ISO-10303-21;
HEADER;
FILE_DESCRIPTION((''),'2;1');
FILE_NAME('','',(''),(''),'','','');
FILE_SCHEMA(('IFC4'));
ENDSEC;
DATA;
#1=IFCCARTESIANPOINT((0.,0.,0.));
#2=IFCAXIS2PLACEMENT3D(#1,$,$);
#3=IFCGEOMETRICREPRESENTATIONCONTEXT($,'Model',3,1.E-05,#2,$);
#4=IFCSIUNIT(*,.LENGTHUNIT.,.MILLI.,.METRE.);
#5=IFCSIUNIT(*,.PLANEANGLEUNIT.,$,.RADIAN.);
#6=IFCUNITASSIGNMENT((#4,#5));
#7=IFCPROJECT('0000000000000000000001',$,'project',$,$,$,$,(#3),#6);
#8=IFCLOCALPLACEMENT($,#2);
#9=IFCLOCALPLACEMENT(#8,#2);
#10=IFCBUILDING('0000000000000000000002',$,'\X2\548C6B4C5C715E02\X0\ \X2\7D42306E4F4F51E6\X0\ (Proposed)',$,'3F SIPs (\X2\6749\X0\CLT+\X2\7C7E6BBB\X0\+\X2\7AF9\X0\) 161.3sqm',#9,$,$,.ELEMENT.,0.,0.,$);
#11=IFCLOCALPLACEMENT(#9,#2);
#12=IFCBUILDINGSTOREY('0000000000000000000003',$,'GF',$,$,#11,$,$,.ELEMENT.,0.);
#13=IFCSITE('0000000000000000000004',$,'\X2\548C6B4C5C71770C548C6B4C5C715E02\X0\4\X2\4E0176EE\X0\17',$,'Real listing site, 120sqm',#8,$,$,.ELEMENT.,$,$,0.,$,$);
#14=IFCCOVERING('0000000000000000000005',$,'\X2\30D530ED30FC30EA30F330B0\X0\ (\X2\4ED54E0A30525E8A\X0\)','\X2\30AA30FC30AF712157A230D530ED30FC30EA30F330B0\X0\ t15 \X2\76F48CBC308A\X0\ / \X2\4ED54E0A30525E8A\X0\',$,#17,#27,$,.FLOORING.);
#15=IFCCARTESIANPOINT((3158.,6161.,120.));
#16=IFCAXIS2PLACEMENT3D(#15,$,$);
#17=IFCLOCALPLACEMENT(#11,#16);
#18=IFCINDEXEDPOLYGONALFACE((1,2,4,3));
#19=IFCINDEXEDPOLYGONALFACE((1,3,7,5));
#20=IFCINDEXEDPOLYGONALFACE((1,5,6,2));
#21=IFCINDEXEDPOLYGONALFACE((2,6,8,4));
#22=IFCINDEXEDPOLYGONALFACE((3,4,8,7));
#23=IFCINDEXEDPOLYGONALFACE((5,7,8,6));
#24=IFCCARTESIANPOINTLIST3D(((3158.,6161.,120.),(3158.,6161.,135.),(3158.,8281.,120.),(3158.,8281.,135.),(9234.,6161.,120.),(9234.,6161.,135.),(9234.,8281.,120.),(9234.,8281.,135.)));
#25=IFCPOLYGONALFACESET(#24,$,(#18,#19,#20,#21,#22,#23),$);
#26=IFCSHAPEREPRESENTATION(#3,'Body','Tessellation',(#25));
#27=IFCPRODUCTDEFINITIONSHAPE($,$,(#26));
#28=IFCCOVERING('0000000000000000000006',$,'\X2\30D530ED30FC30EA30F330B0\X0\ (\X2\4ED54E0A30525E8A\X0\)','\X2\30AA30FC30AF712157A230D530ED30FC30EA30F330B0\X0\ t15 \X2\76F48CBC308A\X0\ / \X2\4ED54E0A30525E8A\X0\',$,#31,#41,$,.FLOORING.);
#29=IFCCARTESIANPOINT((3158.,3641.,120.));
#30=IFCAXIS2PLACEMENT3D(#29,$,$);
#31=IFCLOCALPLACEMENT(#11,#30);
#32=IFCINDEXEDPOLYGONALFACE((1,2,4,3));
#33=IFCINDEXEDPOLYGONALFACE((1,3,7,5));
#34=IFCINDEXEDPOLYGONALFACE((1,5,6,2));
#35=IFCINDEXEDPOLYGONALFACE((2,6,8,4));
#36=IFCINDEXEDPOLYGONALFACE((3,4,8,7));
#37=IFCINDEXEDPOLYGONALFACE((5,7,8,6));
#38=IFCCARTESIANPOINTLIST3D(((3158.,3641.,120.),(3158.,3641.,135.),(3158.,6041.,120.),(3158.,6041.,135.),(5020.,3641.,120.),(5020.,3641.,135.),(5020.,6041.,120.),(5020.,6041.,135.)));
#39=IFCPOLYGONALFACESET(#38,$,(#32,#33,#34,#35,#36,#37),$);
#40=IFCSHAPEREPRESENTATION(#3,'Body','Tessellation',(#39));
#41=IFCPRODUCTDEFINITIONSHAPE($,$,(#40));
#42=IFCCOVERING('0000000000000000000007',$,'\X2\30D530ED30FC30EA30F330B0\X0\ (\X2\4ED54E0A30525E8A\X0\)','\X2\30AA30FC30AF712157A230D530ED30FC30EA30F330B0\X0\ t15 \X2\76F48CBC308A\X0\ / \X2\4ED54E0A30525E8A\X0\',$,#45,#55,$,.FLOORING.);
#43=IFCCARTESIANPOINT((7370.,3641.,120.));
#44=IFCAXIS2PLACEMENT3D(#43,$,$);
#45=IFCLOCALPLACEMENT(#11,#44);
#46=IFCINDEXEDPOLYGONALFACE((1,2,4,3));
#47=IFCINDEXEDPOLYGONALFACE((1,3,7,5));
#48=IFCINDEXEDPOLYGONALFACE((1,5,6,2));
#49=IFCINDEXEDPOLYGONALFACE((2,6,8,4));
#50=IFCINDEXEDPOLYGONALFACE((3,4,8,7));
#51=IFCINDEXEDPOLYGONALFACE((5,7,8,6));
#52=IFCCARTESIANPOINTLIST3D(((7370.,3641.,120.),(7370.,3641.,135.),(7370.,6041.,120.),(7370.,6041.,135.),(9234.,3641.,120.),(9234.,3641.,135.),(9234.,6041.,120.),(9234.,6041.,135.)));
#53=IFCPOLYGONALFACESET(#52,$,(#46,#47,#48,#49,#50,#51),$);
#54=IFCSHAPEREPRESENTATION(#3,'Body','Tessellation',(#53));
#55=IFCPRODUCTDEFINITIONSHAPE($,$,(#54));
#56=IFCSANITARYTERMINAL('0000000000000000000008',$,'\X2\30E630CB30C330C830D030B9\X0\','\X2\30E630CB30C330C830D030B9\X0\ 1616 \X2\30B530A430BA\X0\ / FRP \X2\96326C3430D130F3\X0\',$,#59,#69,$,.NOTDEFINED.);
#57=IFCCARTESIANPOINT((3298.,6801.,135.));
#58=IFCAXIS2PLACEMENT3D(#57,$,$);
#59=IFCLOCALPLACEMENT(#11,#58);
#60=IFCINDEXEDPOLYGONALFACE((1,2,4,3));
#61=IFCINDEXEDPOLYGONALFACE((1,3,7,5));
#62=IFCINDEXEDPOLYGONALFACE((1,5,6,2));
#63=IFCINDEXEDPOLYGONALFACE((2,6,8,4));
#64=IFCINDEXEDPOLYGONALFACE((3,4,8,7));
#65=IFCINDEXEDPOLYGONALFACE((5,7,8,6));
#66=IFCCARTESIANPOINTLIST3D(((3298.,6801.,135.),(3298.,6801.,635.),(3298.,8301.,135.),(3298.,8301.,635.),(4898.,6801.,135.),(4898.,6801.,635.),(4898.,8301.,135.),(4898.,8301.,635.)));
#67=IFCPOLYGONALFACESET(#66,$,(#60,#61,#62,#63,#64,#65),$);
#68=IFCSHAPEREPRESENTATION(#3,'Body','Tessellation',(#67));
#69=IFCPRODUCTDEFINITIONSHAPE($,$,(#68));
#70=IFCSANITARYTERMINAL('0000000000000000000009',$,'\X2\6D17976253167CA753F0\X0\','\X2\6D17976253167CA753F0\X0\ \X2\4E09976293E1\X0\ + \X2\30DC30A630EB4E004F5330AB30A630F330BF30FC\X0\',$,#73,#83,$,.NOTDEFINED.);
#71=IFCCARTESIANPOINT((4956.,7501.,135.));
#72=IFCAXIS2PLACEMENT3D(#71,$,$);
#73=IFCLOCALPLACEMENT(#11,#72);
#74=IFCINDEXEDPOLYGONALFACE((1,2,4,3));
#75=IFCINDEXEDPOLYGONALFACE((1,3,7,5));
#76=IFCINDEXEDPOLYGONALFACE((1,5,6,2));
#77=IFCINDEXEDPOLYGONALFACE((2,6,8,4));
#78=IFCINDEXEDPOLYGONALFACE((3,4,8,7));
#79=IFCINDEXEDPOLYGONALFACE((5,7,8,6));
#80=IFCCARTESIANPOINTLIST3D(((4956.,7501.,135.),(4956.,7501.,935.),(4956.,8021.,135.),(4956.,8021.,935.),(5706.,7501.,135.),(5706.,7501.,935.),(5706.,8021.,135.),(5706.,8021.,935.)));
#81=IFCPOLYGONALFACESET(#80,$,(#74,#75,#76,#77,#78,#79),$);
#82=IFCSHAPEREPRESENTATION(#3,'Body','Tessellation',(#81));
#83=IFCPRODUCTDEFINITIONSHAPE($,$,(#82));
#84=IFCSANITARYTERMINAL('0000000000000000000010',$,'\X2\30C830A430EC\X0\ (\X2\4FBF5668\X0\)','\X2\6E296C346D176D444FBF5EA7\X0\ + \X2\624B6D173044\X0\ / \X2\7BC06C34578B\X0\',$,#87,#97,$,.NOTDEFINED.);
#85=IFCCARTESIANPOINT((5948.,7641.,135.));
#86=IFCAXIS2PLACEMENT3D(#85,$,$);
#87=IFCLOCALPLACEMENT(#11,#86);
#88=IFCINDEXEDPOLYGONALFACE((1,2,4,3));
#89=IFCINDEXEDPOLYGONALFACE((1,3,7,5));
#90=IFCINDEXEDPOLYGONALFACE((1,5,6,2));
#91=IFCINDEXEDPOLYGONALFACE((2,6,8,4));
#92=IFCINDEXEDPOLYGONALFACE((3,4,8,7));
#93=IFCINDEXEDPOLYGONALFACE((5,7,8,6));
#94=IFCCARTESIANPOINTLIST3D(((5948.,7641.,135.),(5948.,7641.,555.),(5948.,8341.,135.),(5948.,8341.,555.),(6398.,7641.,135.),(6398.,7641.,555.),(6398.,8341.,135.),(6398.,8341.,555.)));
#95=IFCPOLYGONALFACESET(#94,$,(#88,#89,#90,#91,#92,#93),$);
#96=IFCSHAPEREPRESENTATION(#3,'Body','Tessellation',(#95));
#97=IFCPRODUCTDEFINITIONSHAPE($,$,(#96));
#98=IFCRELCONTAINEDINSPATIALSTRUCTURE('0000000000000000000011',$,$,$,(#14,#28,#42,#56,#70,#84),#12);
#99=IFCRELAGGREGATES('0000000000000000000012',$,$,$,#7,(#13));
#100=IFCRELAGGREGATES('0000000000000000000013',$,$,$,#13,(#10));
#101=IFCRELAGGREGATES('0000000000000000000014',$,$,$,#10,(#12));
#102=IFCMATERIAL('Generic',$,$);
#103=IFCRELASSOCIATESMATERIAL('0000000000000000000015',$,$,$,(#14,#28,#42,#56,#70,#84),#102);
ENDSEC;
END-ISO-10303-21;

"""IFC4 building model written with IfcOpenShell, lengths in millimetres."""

from ifc_helpers import new_model, si_unit, frame, frame_2d, origin, place, context, project, spatial, rectangle, extrude, material, element, save


model = new_model("IFC4")

# Units and contexts
model_context = context("Model", 3, precision=1e-05, world=origin())
ifc_project = project(units=[si_unit("LENGTHUNIT", "METRE", prefix="MILLI"), si_unit("PLANEANGLEUNIT", "RADIAN")], contexts=[model_context])

# Site, building, storey
site_placement = place(None, origin())
site = spatial("IfcSite", under=ifc_project, at=site_placement, Name="和歌山県和歌山市4丁目17", ObjectType="Real listing site, 120sqm", CompositionType="ELEMENT", RefElevation=0.0)
building_placement = place(site_placement, origin())
building = spatial("IfcBuilding", under=site, at=building_placement, Name="和歌山市 終の住処 (Proposed)", ObjectType="3F SIPs (杉CLT+籾殻+竹) 161.3sqm", CompositionType="ELEMENT", ElevationOfRefHeight=0.0, ElevationOfTerrain=0.0)
storey_placement = place(building_placement, origin())
storey = spatial("IfcBuildingStorey", under=building, at=storey_placement, Name="GF", CompositionType="ELEMENT", Elevation=0.0)

# Coverings
ifc_material_1 = material(Name="Generic")
covering_1_placement = place(storey_placement, frame((3158.0, 6161.0, 120.0)))
element("IfcCovering", 1, at=covering_1_placement, inside=storey, material=ifc_material_1, Name="フローリング (仕上げ床)", Description="オーク無垢フローリング t15 直貼り / 仕上げ床", PredefinedType="FLOORING", context=model_context, shape_type="SweptSolid", body=[
    extrude(rectangle(XDim=6076.0, YDim=2120.0, at=frame_2d((3038.0, 1060.0))), frame((3158.0, 6161.0, 120.0)), (0.0, 0.0, 1.0), 15.0),
])
covering_2_placement = place(storey_placement, frame((3158.0, 3641.0, 120.0)))
element("IfcCovering", 2, at=covering_2_placement, inside=storey, material=ifc_material_1, Name="フローリング (仕上げ床)", Description="オーク無垢フローリング t15 直貼り / 仕上げ床", PredefinedType="FLOORING", context=model_context, shape_type="SweptSolid", body=[
    extrude(rectangle(XDim=1862.0, YDim=2400.0, at=frame_2d((931.0, 1200.0))), frame((3158.0, 3641.0, 120.0)), (0.0, 0.0, 1.0), 15.0),
])
covering_3_placement = place(storey_placement, frame((7370.0, 3641.0, 120.0)))
element("IfcCovering", 3, at=covering_3_placement, inside=storey, material=ifc_material_1, Name="フローリング (仕上げ床)", Description="オーク無垢フローリング t15 直貼り / 仕上げ床", PredefinedType="FLOORING", context=model_context, shape_type="SweptSolid", body=[
    extrude(rectangle(XDim=1864.0, YDim=2400.0, at=frame_2d((932.0, 1200.0))), frame((7370.0, 3641.0, 120.0)), (0.0, 0.0, 1.0), 15.0),
])

# Sanitary terminals
sanitary_terminal_1_placement = place(storey_placement, frame((3298.0, 6801.0, 135.0)))
element("IfcSanitaryTerminal", 4, at=sanitary_terminal_1_placement, inside=storey, material=ifc_material_1, Name="ユニットバス", Description="ユニットバス 1616 サイズ / FRP 防水パン", PredefinedType="NOTDEFINED", context=model_context, shape_type="SweptSolid", body=[
    extrude(rectangle(XDim=1600.0, YDim=1500.0, at=frame_2d((800.0, 750.0))), frame((3298.0, 6801.0, 135.0)), (0.0, 0.0, 1.0), 500.0),
])
sanitary_terminal_2_placement = place(storey_placement, frame((4956.0, 7501.0, 135.0)))
element("IfcSanitaryTerminal", 5, at=sanitary_terminal_2_placement, inside=storey, material=ifc_material_1, Name="洗面化粧台", Description="洗面化粧台 三面鏡 + ボウル一体カウンター", PredefinedType="NOTDEFINED", context=model_context, shape_type="SweptSolid", body=[
    extrude(rectangle(XDim=750.0, YDim=520.0, at=frame_2d((375.0, 260.0))), frame((4956.0, 7501.0, 135.0)), (0.0, 0.0, 1.0), 800.0),
])
sanitary_terminal_3_placement = place(storey_placement, frame((5948.0, 7641.0, 135.0)))
element("IfcSanitaryTerminal", 6, at=sanitary_terminal_3_placement, inside=storey, material=ifc_material_1, Name="トイレ (便器)", Description="温水洗浄便座 + 手洗い / 節水型", PredefinedType="NOTDEFINED", context=model_context, shape_type="SweptSolid", body=[
    extrude(rectangle(XDim=450.0, YDim=700.0, at=frame_2d((225.0, 350.0))), frame((5948.0, 7641.0, 135.0)), (0.0, 0.0, 1.0), 420.0),
])

save(model, "model.ifc")
